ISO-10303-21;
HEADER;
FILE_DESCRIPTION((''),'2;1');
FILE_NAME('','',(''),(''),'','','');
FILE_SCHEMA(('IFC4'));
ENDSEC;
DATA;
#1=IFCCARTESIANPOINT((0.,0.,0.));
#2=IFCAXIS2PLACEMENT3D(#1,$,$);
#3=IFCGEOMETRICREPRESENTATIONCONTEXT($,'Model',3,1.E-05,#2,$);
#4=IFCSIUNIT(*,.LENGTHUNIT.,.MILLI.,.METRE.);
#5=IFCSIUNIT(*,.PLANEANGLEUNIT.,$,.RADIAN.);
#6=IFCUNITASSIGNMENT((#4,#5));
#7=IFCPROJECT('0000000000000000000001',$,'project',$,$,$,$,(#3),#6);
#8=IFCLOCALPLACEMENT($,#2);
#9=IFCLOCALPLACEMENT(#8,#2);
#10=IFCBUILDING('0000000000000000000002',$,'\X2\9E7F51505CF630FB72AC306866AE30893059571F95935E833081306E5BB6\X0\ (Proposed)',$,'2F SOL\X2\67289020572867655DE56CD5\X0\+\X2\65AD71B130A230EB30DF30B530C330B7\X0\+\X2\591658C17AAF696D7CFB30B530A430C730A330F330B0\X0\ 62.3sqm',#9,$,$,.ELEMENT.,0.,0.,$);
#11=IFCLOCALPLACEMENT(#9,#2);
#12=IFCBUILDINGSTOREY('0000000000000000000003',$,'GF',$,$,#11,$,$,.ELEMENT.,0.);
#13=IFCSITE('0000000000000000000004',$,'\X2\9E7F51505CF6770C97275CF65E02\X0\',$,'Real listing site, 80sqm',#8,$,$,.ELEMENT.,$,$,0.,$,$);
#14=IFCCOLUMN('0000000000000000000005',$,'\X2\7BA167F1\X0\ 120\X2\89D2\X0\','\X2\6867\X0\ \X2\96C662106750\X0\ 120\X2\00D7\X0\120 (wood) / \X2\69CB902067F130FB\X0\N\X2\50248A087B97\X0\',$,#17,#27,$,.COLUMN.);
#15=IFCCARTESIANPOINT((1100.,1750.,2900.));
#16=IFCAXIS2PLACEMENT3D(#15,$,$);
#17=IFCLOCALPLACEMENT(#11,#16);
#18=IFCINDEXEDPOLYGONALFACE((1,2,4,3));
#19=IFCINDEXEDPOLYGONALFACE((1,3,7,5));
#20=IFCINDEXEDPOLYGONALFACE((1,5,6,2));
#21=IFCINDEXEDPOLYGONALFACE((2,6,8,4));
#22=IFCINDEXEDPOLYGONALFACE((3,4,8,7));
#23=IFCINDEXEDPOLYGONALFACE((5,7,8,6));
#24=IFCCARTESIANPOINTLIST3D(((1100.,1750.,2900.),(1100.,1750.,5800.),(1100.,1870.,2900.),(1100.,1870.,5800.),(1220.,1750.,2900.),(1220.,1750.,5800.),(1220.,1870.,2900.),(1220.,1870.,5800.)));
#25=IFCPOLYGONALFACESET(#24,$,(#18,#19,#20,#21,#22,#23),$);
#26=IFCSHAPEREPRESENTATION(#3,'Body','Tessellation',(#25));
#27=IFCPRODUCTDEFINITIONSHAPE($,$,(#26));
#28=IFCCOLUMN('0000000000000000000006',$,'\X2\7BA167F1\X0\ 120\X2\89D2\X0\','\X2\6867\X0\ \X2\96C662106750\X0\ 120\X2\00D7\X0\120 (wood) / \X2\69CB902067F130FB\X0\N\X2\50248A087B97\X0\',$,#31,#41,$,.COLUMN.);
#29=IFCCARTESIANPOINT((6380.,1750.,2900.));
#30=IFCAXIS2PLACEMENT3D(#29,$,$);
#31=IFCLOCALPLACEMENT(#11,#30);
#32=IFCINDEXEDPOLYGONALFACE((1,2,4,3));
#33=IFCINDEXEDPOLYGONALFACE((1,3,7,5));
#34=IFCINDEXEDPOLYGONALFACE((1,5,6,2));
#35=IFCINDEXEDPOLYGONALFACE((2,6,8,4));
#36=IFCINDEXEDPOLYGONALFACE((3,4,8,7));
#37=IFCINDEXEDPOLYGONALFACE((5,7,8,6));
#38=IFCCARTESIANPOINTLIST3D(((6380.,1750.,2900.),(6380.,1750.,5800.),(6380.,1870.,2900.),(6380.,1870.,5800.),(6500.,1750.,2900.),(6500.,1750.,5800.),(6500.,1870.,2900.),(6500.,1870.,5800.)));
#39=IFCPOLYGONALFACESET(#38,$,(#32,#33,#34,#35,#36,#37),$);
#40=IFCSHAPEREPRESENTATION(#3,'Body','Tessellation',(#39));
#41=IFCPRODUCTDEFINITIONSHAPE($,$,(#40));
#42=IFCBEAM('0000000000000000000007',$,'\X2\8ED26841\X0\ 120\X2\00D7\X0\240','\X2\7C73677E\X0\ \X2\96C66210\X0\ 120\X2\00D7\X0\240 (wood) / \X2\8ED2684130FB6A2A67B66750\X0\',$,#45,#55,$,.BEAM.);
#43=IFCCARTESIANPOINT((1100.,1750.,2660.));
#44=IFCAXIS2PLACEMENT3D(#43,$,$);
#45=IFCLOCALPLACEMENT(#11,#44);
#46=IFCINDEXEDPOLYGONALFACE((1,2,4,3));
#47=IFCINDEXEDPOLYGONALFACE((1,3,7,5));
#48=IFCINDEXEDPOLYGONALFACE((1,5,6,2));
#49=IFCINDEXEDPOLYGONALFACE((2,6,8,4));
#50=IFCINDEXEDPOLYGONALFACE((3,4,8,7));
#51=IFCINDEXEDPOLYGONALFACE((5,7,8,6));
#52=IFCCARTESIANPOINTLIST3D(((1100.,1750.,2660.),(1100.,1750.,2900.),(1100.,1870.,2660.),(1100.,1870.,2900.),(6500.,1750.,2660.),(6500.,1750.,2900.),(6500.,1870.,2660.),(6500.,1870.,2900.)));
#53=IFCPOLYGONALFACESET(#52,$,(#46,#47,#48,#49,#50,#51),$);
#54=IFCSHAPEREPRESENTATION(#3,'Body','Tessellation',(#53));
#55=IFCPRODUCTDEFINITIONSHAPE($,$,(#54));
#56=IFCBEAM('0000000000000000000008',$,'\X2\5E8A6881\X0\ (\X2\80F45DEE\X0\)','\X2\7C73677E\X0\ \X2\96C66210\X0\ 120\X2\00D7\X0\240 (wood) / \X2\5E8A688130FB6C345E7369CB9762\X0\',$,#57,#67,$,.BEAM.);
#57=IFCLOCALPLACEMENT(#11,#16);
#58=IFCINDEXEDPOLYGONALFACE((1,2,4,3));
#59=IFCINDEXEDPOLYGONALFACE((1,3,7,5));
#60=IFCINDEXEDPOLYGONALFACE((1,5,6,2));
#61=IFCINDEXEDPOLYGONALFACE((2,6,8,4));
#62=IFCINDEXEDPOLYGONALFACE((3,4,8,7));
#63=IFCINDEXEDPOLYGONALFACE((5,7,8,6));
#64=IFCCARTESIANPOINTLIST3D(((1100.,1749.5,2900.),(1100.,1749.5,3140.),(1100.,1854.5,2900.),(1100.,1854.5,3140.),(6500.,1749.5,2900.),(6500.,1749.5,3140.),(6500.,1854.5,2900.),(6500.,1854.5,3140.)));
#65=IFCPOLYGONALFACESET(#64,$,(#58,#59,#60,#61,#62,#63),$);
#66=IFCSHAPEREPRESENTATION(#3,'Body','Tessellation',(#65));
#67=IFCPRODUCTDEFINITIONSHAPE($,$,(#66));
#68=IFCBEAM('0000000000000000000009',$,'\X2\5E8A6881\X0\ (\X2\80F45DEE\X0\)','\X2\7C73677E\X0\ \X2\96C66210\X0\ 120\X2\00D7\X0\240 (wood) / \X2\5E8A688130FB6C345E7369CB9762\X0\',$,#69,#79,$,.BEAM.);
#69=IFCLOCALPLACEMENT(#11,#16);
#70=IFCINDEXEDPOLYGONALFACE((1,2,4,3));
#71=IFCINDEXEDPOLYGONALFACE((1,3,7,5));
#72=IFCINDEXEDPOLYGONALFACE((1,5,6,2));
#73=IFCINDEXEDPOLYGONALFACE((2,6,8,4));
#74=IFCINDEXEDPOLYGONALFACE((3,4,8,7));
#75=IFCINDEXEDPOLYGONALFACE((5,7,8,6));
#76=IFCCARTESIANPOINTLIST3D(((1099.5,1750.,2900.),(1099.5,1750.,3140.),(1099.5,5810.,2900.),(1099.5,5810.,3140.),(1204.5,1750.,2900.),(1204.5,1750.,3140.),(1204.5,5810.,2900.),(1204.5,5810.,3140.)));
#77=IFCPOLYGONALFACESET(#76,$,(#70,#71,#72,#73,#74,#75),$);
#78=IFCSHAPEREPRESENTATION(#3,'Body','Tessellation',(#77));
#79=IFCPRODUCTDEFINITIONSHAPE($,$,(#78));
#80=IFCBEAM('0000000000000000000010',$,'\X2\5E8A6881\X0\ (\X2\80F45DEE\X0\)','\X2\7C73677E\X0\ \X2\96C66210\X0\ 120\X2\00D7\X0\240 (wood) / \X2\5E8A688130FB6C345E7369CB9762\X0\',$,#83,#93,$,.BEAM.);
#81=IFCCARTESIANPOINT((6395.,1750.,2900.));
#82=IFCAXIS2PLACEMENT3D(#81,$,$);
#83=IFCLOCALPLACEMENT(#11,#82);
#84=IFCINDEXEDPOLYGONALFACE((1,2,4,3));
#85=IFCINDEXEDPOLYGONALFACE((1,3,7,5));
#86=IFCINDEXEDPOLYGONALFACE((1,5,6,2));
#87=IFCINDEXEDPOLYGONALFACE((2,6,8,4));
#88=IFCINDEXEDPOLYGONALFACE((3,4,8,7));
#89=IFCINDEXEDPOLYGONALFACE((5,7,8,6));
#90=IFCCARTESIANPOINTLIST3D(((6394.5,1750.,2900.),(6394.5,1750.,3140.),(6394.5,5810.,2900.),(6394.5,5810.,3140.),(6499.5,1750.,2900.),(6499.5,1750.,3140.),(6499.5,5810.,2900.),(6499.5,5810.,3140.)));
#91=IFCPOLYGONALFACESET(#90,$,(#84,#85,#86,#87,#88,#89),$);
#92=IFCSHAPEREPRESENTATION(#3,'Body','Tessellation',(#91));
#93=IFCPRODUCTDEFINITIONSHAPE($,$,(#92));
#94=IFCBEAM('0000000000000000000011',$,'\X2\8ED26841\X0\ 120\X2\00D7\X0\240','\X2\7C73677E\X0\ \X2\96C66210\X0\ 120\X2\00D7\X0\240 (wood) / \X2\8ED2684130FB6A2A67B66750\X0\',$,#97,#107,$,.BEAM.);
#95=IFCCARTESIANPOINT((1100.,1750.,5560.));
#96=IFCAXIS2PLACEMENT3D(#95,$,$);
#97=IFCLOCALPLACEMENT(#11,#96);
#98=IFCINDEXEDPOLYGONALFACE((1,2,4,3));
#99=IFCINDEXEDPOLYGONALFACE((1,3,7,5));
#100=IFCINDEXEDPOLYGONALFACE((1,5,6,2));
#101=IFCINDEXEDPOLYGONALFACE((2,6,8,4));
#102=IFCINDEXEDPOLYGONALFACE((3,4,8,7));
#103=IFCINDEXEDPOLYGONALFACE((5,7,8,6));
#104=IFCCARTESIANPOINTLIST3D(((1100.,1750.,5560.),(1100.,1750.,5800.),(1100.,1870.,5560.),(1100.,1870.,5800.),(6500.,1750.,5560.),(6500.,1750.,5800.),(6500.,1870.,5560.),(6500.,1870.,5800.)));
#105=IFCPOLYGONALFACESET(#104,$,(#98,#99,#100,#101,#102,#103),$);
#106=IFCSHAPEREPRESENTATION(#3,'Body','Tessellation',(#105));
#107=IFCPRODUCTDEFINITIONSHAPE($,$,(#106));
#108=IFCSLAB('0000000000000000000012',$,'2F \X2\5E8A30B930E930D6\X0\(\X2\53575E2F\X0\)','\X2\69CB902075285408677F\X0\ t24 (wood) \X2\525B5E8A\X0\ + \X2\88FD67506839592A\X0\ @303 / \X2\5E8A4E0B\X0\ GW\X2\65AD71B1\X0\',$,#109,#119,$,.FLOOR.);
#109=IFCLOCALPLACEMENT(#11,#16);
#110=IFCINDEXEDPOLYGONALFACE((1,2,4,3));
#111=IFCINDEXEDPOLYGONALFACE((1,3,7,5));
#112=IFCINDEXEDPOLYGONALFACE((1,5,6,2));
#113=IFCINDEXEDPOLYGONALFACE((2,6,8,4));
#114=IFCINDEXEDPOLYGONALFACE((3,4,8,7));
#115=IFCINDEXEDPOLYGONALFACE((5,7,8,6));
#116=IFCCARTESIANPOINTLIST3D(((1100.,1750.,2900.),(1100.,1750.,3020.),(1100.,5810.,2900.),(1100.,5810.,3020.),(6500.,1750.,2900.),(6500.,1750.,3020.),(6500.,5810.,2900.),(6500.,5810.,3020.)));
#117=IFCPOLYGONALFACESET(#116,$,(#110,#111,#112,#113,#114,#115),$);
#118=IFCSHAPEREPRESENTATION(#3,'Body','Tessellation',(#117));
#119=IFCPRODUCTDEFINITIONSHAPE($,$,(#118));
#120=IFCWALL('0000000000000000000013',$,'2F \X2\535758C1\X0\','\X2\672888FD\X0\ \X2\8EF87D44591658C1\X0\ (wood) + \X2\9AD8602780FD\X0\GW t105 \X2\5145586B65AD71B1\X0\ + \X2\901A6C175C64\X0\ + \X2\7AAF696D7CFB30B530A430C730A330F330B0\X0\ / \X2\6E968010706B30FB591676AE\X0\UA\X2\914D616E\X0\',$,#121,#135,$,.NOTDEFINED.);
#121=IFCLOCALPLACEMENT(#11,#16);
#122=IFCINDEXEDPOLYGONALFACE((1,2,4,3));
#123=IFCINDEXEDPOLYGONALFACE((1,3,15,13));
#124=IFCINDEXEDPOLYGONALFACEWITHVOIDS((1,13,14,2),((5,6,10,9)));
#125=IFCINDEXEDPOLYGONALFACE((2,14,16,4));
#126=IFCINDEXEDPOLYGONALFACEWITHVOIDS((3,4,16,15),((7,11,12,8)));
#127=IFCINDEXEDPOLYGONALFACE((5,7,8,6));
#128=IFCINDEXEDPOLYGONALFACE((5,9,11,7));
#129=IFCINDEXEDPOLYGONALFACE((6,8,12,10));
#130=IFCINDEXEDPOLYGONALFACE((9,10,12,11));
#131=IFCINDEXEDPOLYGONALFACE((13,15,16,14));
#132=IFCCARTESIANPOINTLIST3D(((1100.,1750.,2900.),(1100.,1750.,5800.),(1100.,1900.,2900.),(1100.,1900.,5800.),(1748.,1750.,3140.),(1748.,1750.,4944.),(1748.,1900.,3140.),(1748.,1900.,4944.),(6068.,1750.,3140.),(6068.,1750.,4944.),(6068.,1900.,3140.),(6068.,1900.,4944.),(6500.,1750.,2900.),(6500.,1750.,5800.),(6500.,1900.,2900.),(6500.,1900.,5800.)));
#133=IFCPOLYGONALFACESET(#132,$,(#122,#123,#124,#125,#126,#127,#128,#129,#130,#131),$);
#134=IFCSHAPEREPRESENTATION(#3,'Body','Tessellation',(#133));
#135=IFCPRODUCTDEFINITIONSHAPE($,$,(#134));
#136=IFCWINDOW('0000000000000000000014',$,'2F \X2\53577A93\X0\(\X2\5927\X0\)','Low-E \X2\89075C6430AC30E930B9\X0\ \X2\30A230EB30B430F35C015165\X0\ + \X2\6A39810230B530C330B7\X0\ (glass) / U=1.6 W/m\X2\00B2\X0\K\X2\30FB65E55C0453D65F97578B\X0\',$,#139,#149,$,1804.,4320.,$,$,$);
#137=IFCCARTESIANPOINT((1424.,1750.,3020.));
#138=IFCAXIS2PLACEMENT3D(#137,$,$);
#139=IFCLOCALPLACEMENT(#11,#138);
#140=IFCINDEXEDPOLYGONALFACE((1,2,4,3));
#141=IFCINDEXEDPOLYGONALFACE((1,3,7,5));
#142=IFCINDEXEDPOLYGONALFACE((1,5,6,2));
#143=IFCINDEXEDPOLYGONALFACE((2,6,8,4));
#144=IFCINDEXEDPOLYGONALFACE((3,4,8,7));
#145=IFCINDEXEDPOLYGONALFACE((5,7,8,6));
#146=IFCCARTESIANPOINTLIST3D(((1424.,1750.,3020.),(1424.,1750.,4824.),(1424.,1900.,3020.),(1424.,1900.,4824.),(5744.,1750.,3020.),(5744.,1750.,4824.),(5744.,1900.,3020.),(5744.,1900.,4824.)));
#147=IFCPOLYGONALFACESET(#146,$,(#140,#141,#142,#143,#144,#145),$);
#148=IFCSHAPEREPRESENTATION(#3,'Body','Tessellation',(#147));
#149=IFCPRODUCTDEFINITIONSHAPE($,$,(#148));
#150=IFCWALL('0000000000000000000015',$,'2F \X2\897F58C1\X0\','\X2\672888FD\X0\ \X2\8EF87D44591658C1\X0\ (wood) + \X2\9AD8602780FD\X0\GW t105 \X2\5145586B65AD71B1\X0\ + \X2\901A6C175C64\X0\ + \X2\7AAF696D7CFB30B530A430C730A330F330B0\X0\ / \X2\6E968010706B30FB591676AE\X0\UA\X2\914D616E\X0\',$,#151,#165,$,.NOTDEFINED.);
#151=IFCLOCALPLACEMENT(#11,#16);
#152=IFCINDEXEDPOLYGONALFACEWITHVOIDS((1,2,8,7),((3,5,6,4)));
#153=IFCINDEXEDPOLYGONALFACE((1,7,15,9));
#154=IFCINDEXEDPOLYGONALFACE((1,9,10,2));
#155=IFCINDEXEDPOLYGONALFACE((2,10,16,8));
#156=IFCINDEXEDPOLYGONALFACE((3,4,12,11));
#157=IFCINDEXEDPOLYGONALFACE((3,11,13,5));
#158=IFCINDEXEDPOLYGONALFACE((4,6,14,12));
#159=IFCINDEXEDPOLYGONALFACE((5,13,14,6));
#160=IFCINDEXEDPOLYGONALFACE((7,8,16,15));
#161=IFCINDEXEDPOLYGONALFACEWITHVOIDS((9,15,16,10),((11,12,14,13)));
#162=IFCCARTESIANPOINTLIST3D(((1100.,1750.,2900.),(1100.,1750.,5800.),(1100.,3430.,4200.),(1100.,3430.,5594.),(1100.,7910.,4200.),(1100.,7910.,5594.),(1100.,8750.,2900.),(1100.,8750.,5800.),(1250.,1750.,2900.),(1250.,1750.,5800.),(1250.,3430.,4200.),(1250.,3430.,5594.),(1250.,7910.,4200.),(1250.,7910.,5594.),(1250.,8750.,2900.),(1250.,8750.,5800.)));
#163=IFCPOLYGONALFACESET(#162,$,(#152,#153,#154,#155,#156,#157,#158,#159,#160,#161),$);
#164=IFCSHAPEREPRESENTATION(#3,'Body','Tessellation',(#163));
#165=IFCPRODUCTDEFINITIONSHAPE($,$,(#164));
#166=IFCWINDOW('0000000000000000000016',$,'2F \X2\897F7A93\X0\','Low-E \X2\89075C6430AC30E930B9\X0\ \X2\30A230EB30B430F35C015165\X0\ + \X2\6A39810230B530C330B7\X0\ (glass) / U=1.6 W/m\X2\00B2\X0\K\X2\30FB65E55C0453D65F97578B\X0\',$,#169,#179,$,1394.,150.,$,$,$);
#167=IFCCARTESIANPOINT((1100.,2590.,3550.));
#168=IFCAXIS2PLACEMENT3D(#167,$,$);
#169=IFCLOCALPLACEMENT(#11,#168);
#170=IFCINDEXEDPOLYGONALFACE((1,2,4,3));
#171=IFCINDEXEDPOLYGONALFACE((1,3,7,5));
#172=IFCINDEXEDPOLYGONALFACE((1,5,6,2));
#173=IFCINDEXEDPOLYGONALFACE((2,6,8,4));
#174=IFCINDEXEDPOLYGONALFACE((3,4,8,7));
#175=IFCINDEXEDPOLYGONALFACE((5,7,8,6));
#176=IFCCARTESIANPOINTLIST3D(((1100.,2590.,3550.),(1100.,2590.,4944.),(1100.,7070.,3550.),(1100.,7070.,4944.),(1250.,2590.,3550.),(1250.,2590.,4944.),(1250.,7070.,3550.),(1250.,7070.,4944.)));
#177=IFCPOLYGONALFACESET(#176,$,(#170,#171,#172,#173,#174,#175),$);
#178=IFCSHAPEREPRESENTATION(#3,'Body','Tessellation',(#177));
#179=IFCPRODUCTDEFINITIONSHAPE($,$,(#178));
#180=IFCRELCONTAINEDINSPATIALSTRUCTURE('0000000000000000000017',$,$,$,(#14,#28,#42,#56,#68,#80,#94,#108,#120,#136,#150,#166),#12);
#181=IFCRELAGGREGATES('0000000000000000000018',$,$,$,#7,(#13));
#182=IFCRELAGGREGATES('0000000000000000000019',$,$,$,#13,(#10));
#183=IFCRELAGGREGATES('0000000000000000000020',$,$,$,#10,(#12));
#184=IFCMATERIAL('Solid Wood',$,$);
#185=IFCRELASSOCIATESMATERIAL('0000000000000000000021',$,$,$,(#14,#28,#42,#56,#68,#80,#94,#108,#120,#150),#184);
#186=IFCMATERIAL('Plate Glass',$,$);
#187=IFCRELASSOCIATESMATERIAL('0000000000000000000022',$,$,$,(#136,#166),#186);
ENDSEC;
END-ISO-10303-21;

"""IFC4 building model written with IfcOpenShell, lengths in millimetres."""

from ifc_helpers import new_model, si_unit, frame, frame_2d, origin, place, context, project, spatial, rectangle, extrude, material, element, fill, save


model = new_model("IFC4")

# Units and contexts
model_context = context("Model", 3, precision=1e-05, world=origin())
ifc_project = project(units=[si_unit("LENGTHUNIT", "METRE", prefix="MILLI"), si_unit("PLANEANGLEUNIT", "RADIAN")], contexts=[model_context])

# Site, building, storey
site_placement = place(None, origin())
site = spatial("IfcSite", under=ifc_project, at=site_placement, Name="鹿児島県霧島市", ObjectType="Real listing site, 80sqm", CompositionType="ELEMENT", RefElevation=0.0)
building_placement = place(site_placement, origin())
building = spatial("IfcBuilding", under=site, at=building_placement, Name="鹿児島・犬と暮らす土間広めの家 (Proposed)", ObjectType="2F SOL木造在来工法+断熱アルミサッシ+外壁窯業系サイディング 62.3sqm", CompositionType="ELEMENT", ElevationOfRefHeight=0.0, ElevationOfTerrain=0.0)
storey_placement = place(building_placement, origin())
storey = spatial("IfcBuildingStorey", under=building, at=storey_placement, Name="GF", CompositionType="ELEMENT", Elevation=0.0)

# Columns
ifc_material_1 = material(Name="Solid Wood")
column_1_placement = place(storey_placement, frame((1100.0, 1750.0, 2900.0)))
element("IfcColumn", 1, at=column_1_placement, inside=storey, material=ifc_material_1, Name="管柱 120角", Description="桧 集成材 120×120 (wood) / 構造柱・N値計算", PredefinedType="COLUMN", context=model_context, shape_type="SweptSolid", body=[
    extrude(rectangle(XDim=120.0, YDim=120.0, at=frame_2d((60.0, 60.0))), frame((1100.0, 1750.0, 2900.0)), (0.0, 0.0, 1.0), 2900.0),
])
column_2_placement = place(storey_placement, frame((6380.0, 1750.0, 2900.0)))
element("IfcColumn", 2, at=column_2_placement, inside=storey, material=ifc_material_1, Name="管柱 120角", Description="桧 集成材 120×120 (wood) / 構造柱・N値計算", PredefinedType="COLUMN", context=model_context, shape_type="SweptSolid", body=[
    extrude(rectangle(XDim=120.0, YDim=120.0, at=frame_2d((60.0, 60.0))), frame((6380.0, 1750.0, 2900.0)), (0.0, 0.0, 1.0), 2900.0),
])

# Beams
beam_1_placement = place(storey_placement, frame((1100.0, 1750.0, 2660.0)))
element("IfcBeam", 3, at=beam_1_placement, inside=storey, material=ifc_material_1, Name="軒桁 120×240", Description="米松 集成 120×240 (wood) / 軒桁・横架材", PredefinedType="BEAM", context=model_context, shape_type="SweptSolid", body=[
    extrude(rectangle(XDim=5400.0, YDim=120.0, at=frame_2d((2700.0, 60.0))), frame((1100.0, 1750.0, 2660.0)), (0.0, 0.0, 1.0), 240.0),
])
beam_2_placement = place(storey_placement, frame((1100.0, 1750.0, 2900.0)))
element("IfcBeam", 4, at=beam_2_placement, inside=storey, material=ifc_material_1, Name="床梁 (胴差)", Description="米松 集成 120×240 (wood) / 床梁・水平構面", PredefinedType="BEAM", context=model_context, shape_type="SweptSolid", body=[
    extrude(rectangle(XDim=5400.0, YDim=105.0, at=frame_2d((2700.0, 52.0))), frame((1100.0, 1750.0, 2900.0)), (0.0, 0.0, 1.0), 240.0),
])
beam_3_placement = place(storey_placement, frame((1100.0, 1750.0, 2900.0)))
element("IfcBeam", 5, at=beam_3_placement, inside=storey, material=ifc_material_1, Name="床梁 (胴差)", Description="米松 集成 120×240 (wood) / 床梁・水平構面", PredefinedType="BEAM", context=model_context, shape_type="SweptSolid", body=[
    extrude(rectangle(XDim=105.0, YDim=4060.0, at=frame_2d((52.0, 2030.0))), frame((1100.0, 1750.0, 2900.0)), (0.0, 0.0, 1.0), 240.0),
])
beam_4_placement = place(storey_placement, frame((6395.0, 1750.0, 2900.0)))
element("IfcBeam", 6, at=beam_4_placement, inside=storey, material=ifc_material_1, Name="床梁 (胴差)", Description="米松 集成 120×240 (wood) / 床梁・水平構面", PredefinedType="BEAM", context=model_context, shape_type="SweptSolid", body=[
    extrude(rectangle(XDim=105.0, YDim=4060.0, at=frame_2d((52.0, 2030.0))), frame((6395.0, 1750.0, 2900.0)), (0.0, 0.0, 1.0), 240.0),
])
beam_5_placement = place(storey_placement, frame((1100.0, 1750.0, 5560.0)))
element("IfcBeam", 7, at=beam_5_placement, inside=storey, material=ifc_material_1, Name="軒桁 120×240", Description="米松 集成 120×240 (wood) / 軒桁・横架材", PredefinedType="BEAM", context=model_context, shape_type="SweptSolid", body=[
    extrude(rectangle(XDim=5400.0, YDim=120.0, at=frame_2d((2700.0, 60.0))), frame((1100.0, 1750.0, 5560.0)), (0.0, 0.0, 1.0), 240.0),
])

# Slab
slab_placement = place(storey_placement, frame((1100.0, 1750.0, 2900.0)))
element("IfcSlab", 8, at=slab_placement, inside=storey, material=ifc_material_1, Name="2F 床スラブ(南帯)", Description="構造用合板 t24 (wood) 剛床 + 製材根太 @303 / 床下 GW断熱", PredefinedType="FLOOR", context=model_context, shape_type="SweptSolid", body=[
    extrude(rectangle(XDim=5400.0, YDim=4060.0, at=frame_2d((2700.0, 2030.0))), frame((1100.0, 1750.0, 2900.0)), (0.0, 0.0, 1.0), 120.0),
])

# Walls, openings, windows
wall_1_placement = place(storey_placement, frame((1100.0, 1750.0, 2900.0)))
wall_1 = element("IfcWall", 9, at=wall_1_placement, inside=storey, material=ifc_material_1, Name="2F 南壁", Description="木製 軸組外壁 (wood) + 高性能GW t105 充填断熱 + 通気層 + 窯業系サイディング / 準耐火・外皮UA配慮", PredefinedType="NOTDEFINED", context=model_context, shape_type="SweptSolid", body=[
    extrude(rectangle(XDim=5400.0, YDim=150.0, at=frame_2d((2700.0, 75.0))), frame((1100.0, 1750.0, 2900.0)), (0.0, 0.0, 1.0), 2900.0),
])
opening_1_placement = place(storey_placement, frame((1424.0, 1750.0, 3020.0)))
opening_1 = element("IfcOpeningElement", 10, at=opening_1_placement, cuts=wall_1, PredefinedType="NOTDEFINED", context=model_context, shape_type="SweptSolid", body=[
    extrude(rectangle(XDim=4320.0, YDim=150.0, at=frame_2d((2160.0, 75.0))), frame((1424.0, 1750.0, 3020.0)), (0.0, 0.0, 1.0), 1804.0),
])
ifc_material_2 = material(Name="Plate Glass")
window_1_placement = place(storey_placement, frame((1424.0, 1750.0, 3020.0)))
window_1 = element("IfcWindow", 11, at=window_1_placement, inside=storey, material=ifc_material_2, Name="2F 南窓(大)", Description="Low-E 複層ガラス アルゴン封入 + 樹脂サッシ (glass) / U=1.6 W/m²K・日射取得型", OverallHeight=1804.0, OverallWidth=4320.0, context=model_context, shape_type="SweptSolid", body=[
    extrude(rectangle(XDim=4320.0, YDim=150.0, at=frame_2d((2160.0, 75.0))), frame((1424.0, 1750.0, 3020.0)), (0.0, 0.0, 1.0), 1804.0),
])
fill(opening_1, window_1)
wall_2_placement = place(storey_placement, frame((1100.0, 1750.0, 2900.0)))
wall_2 = element("IfcWall", 12, at=wall_2_placement, inside=storey, material=ifc_material_1, Name="2F 西壁", Description="木製 軸組外壁 (wood) + 高性能GW t105 充填断熱 + 通気層 + 窯業系サイディング / 準耐火・外皮UA配慮", PredefinedType="NOTDEFINED", context=model_context, shape_type="SweptSolid", body=[
    extrude(rectangle(XDim=150.0, YDim=7000.0, at=frame_2d((75.0, 3500.0))), frame((1100.0, 1750.0, 2900.0)), (0.0, 0.0, 1.0), 2900.0),
])
opening_2_placement = place(storey_placement, frame((1100.0, 2590.0, 3550.0)))
opening_2 = element("IfcOpeningElement", 13, at=opening_2_placement, cuts=wall_2, PredefinedType="NOTDEFINED", context=model_context, shape_type="SweptSolid", body=[
    extrude(rectangle(XDim=150.0, YDim=4480.0, at=frame_2d((75.0, 2240.0))), frame((1100.0, 2590.0, 3550.0)), (0.0, 0.0, 1.0), 1394.0),
])
window_2_placement = place(storey_placement, frame((1100.0, 2590.0, 3550.0)))
window_2 = element("IfcWindow", 14, at=window_2_placement, inside=storey, material=ifc_material_2, Name="2F 西窓", Description="Low-E 複層ガラス アルゴン封入 + 樹脂サッシ (glass) / U=1.6 W/m²K・日射取得型", OverallHeight=1394.0, OverallWidth=150.0, context=model_context, shape_type="SweptSolid", body=[
    extrude(rectangle(XDim=150.0, YDim=4480.0, at=frame_2d((75.0, 2240.0))), frame((1100.0, 2590.0, 3550.0)), (0.0, 0.0, 1.0), 1394.0),
])
fill(opening_2, window_2)

save(model, "model.ifc")
